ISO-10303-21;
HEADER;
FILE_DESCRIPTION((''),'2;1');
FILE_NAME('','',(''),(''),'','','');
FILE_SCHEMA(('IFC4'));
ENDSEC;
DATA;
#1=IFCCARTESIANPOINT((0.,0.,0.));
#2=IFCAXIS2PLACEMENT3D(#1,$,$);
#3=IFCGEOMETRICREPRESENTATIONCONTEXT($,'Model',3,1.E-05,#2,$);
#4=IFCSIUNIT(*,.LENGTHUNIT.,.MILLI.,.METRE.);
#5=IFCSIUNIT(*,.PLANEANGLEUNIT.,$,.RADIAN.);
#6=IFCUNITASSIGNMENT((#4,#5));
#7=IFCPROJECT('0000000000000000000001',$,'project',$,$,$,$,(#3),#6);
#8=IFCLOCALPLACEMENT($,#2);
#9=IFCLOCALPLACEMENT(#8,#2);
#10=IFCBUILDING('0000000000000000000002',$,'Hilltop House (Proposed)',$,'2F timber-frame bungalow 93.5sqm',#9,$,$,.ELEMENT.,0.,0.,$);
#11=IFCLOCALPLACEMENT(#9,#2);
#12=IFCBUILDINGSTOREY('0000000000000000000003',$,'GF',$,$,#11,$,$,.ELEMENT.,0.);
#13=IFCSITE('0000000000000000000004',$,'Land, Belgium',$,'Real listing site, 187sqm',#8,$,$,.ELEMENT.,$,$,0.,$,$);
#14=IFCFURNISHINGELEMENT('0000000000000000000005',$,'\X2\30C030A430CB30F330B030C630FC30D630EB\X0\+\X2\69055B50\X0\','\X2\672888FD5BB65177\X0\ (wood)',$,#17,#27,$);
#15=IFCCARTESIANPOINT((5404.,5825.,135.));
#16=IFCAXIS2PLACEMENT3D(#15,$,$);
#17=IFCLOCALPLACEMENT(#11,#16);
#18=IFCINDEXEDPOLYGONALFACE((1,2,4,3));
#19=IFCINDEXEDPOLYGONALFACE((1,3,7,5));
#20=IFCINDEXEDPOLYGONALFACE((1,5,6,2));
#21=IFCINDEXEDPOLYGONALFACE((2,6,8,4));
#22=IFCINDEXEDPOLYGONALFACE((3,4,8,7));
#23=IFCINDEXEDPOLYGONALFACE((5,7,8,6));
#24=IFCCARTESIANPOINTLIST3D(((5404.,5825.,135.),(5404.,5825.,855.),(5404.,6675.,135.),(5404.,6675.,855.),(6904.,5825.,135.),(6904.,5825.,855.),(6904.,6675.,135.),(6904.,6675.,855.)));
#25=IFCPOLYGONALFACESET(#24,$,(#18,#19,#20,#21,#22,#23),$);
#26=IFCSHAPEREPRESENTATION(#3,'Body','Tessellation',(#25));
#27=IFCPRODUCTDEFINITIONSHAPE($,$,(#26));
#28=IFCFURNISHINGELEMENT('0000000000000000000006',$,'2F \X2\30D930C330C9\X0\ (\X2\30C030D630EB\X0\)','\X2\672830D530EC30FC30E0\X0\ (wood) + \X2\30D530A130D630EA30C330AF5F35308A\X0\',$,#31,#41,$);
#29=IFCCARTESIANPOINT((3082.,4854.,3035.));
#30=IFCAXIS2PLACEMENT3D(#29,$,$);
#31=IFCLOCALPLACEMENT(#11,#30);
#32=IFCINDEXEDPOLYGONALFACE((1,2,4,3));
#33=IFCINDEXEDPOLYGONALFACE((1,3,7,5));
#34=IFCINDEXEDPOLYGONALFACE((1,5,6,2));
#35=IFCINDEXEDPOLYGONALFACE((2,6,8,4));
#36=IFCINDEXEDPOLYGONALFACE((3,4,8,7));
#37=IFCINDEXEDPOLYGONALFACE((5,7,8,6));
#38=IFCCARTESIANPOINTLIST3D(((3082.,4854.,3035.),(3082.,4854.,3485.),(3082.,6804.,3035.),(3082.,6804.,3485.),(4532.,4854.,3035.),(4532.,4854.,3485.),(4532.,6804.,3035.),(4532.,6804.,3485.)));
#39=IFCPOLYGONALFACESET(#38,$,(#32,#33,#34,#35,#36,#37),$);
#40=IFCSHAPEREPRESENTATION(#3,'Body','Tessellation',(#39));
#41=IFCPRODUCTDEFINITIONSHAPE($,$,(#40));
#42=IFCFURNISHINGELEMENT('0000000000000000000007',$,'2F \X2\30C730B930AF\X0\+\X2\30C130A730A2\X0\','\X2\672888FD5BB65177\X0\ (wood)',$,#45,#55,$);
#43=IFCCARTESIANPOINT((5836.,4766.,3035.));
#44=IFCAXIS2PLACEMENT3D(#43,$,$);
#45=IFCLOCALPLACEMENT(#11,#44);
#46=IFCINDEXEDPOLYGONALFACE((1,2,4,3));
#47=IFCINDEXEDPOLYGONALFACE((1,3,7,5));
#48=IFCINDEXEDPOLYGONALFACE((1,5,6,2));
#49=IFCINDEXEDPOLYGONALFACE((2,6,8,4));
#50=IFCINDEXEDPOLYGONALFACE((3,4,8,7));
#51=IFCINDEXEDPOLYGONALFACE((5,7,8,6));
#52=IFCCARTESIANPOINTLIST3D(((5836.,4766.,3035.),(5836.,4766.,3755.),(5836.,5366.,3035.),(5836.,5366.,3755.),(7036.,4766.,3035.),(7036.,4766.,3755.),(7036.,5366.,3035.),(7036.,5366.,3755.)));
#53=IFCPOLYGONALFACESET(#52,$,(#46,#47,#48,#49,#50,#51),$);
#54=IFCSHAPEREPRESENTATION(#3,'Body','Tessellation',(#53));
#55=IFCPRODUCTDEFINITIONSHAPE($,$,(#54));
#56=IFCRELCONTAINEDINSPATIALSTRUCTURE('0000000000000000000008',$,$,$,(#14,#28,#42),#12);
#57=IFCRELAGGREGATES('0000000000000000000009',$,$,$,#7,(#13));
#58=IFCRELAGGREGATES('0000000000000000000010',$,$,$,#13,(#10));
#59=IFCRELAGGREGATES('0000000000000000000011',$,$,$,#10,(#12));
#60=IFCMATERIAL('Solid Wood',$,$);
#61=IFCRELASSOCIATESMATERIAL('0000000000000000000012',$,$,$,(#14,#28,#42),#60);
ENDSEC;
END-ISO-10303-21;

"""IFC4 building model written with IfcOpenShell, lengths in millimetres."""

from ifc_helpers import new_model, si_unit, frame, frame_2d, origin, place, context, project, spatial, rectangle, extrude, material, element, save


model = new_model("IFC4")

# Units and contexts
model_context = context("Model", 3, precision=1e-05, world=origin())
ifc_project = project(units=[si_unit("LENGTHUNIT", "METRE", prefix="MILLI"), si_unit("PLANEANGLEUNIT", "RADIAN")], contexts=[model_context])

# Site, building, storey
site_placement = place(None, origin())
site = spatial("IfcSite", under=ifc_project, at=site_placement, Name="Land, Belgium", ObjectType="Real listing site, 187sqm", CompositionType="ELEMENT", RefElevation=0.0)
building_placement = place(site_placement, origin())
building = spatial("IfcBuilding", under=site, at=building_placement, Name="Hilltop House (Proposed)", ObjectType="2F timber-frame bungalow 93.5sqm", CompositionType="ELEMENT", ElevationOfRefHeight=0.0, ElevationOfTerrain=0.0)
storey_placement = place(building_placement, origin())
storey = spatial("IfcBuildingStorey", under=building, at=storey_placement, Name="GF", CompositionType="ELEMENT", Elevation=0.0)

# Shared definitions
ifc_material_1 = material(Name="Solid Wood")

# Furnishing elements
furnishing_1_placement = place(storey_placement, frame((5404.0, 5825.0, 135.0)))
element("IfcFurnishingElement", 1, at=furnishing_1_placement, inside=storey, material=ifc_material_1, Name="ダイニングテーブル+椅子", Description="木製家具 (wood)", context=model_context, shape_type="SweptSolid", body=[
    extrude(rectangle(XDim=1500.0, YDim=850.0, at=frame_2d((750.0, 425.0))), frame((5404.0, 5825.0, 135.0)), (0.0, 0.0, 1.0), 720.0),
])
furnishing_2_placement = place(storey_placement, frame((3082.0, 4854.0, 3035.0)))
element("IfcFurnishingElement", 2, at=furnishing_2_placement, inside=storey, material=ifc_material_1, Name="2F ベッド (ダブル)", Description="木フレーム (wood) + ファブリック張り", context=model_context, shape_type="SweptSolid", body=[
    extrude(rectangle(XDim=1450.0, YDim=1950.0, at=frame_2d((725.0, 975.0))), frame((3082.0, 4854.0, 3035.0)), (0.0, 0.0, 1.0), 450.0),
])
furnishing_3_placement = place(storey_placement, frame((5836.0, 4766.0, 3035.0)))
element("IfcFurnishingElement", 3, at=furnishing_3_placement, inside=storey, material=ifc_material_1, Name="2F デスク+チェア", Description="木製家具 (wood)", context=model_context, shape_type="SweptSolid", body=[
    extrude(rectangle(XDim=1200.0, YDim=600.0, at=frame_2d((600.0, 300.0))), frame((5836.0, 4766.0, 3035.0)), (0.0, 0.0, 1.0), 720.0),
])

save(model, "model.ifc")
